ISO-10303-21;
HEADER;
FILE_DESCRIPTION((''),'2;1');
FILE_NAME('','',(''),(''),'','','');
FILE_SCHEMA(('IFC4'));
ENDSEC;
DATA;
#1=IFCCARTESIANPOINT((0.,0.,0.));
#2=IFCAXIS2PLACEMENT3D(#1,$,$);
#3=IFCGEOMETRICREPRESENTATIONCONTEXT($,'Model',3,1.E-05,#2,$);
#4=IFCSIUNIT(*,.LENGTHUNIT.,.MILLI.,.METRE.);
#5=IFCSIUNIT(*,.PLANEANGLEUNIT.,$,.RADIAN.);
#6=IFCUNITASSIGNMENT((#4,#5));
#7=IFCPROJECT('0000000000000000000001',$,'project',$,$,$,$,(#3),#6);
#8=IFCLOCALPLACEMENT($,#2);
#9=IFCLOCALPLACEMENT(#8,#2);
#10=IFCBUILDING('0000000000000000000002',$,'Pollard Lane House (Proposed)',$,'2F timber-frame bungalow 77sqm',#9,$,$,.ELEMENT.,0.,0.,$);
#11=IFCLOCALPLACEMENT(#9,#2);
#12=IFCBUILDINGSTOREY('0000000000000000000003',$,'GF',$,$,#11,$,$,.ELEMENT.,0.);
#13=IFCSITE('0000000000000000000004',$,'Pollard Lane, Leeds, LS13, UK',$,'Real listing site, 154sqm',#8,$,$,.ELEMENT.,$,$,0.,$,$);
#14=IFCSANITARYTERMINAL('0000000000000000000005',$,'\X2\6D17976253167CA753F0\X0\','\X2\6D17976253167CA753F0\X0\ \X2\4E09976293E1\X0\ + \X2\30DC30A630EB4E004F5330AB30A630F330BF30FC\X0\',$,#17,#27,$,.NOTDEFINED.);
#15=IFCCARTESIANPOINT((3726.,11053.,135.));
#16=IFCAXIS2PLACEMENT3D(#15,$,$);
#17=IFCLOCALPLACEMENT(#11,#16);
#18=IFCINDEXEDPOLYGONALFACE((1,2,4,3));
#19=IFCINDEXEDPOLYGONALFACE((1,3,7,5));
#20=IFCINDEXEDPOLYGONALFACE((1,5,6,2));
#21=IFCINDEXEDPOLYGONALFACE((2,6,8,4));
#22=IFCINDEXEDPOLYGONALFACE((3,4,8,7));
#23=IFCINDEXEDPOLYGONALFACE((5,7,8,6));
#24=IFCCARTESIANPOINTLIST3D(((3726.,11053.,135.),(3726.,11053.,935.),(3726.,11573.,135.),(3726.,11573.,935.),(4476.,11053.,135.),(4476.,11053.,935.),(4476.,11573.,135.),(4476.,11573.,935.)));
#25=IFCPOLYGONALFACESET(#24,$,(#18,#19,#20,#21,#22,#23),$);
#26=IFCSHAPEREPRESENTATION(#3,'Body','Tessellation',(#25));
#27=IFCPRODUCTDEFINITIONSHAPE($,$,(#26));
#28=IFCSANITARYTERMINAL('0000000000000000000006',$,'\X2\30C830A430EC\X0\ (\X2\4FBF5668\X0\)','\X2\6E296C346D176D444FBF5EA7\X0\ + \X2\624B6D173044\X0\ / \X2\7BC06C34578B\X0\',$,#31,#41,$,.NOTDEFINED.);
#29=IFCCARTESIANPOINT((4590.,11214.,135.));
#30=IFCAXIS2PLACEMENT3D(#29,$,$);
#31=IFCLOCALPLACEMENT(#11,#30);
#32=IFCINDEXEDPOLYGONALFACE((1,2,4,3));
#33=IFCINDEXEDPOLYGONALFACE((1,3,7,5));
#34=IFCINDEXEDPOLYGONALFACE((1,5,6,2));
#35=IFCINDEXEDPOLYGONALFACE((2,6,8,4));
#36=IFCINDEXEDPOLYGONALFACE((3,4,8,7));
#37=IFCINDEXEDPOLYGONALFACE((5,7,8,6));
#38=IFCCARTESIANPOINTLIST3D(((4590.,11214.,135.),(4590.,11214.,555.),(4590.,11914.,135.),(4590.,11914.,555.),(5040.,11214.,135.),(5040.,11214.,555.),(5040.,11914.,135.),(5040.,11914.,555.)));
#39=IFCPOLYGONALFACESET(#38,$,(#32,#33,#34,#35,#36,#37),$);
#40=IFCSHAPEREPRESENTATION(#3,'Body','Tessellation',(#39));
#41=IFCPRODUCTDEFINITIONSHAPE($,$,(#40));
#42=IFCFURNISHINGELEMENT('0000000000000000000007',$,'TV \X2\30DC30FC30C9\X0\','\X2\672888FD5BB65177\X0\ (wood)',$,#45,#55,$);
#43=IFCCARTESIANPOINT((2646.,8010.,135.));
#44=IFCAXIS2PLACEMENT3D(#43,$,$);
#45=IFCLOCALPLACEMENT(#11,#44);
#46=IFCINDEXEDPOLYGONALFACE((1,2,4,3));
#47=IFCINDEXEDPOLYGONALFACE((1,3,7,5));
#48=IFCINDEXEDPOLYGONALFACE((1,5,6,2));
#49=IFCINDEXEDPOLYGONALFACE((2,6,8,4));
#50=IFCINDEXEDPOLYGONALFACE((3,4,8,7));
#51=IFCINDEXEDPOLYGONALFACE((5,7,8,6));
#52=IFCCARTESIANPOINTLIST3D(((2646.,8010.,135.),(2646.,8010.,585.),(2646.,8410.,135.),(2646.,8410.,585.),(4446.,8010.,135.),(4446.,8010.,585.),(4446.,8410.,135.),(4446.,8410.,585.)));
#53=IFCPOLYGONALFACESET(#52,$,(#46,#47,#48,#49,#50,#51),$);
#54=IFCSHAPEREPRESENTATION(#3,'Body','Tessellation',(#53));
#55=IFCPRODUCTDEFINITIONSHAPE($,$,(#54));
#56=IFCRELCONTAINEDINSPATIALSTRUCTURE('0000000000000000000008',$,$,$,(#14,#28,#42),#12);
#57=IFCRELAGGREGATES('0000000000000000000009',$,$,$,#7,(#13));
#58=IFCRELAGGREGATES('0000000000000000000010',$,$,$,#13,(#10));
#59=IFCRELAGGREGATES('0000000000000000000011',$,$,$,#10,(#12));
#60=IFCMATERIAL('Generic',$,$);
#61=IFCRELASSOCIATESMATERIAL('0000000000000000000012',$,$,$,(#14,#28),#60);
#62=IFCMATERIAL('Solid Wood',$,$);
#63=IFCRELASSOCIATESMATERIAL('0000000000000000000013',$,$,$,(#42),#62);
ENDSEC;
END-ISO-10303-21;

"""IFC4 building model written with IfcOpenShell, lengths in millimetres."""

from ifc_helpers import new_model, si_unit, frame, frame_2d, origin, place, context, project, spatial, rectangle, extrude, material, element, save


model = new_model("IFC4")

# Units and contexts
model_context = context("Model", 3, precision=1e-05, world=origin())
ifc_project = project(units=[si_unit("LENGTHUNIT", "METRE", prefix="MILLI"), si_unit("PLANEANGLEUNIT", "RADIAN")], contexts=[model_context])

# Site, building, storey
site_placement = place(None, origin())
site = spatial("IfcSite", under=ifc_project, at=site_placement, Name="Pollard Lane, Leeds, LS13, UK", ObjectType="Real listing site, 154sqm", CompositionType="ELEMENT", RefElevation=0.0)
building_placement = place(site_placement, origin())
building = spatial("IfcBuilding", under=site, at=building_placement, Name="Pollard Lane House (Proposed)", ObjectType="2F timber-frame bungalow 77sqm", CompositionType="ELEMENT", ElevationOfRefHeight=0.0, ElevationOfTerrain=0.0)
storey_placement = place(building_placement, origin())
storey = spatial("IfcBuildingStorey", under=building, at=storey_placement, Name="GF", CompositionType="ELEMENT", Elevation=0.0)

# Shared definitions
ifc_material_1 = material(Name="Solid Wood")

# Shared definitions
ifc_material_2 = material(Name="Generic")

# Sanitary terminals
sanitary_terminal_1_placement = place(storey_placement, frame((3726.0, 11053.0, 135.0)))
element("IfcSanitaryTerminal", 1, at=sanitary_terminal_1_placement, inside=storey, material=ifc_material_2, Name="洗面化粧台", Description="洗面化粧台 三面鏡 + ボウル一体カウンター", PredefinedType="NOTDEFINED", context=model_context, shape_type="SweptSolid", body=[
    extrude(rectangle(XDim=750.0, YDim=520.0, at=frame_2d((375.0, 260.0))), frame((3726.0, 11053.0, 135.0)), (0.0, 0.0, 1.0), 800.0),
])
sanitary_terminal_2_placement = place(storey_placement, frame((4590.0, 11214.0, 135.0)))
element("IfcSanitaryTerminal", 2, at=sanitary_terminal_2_placement, inside=storey, material=ifc_material_2, Name="トイレ (便器)", Description="温水洗浄便座 + 手洗い / 節水型", PredefinedType="NOTDEFINED", context=model_context, shape_type="SweptSolid", body=[
    extrude(rectangle(XDim=450.0, YDim=700.0, at=frame_2d((225.0, 350.0))), frame((4590.0, 11214.0, 135.0)), (0.0, 0.0, 1.0), 420.0),
])

# Furnishing element
furnishing_placement = place(storey_placement, frame((2646.0, 8010.0, 135.0)))
element("IfcFurnishingElement", 3, at=furnishing_placement, inside=storey, material=ifc_material_1, Name="TV ボード", Description="木製家具 (wood)", context=model_context, shape_type="SweptSolid", body=[
    extrude(rectangle(XDim=1800.0, YDim=400.0, at=frame_2d((900.0, 200.0))), frame((2646.0, 8010.0, 135.0)), (0.0, 0.0, 1.0), 450.0),
])

save(model, "model.ifc")
